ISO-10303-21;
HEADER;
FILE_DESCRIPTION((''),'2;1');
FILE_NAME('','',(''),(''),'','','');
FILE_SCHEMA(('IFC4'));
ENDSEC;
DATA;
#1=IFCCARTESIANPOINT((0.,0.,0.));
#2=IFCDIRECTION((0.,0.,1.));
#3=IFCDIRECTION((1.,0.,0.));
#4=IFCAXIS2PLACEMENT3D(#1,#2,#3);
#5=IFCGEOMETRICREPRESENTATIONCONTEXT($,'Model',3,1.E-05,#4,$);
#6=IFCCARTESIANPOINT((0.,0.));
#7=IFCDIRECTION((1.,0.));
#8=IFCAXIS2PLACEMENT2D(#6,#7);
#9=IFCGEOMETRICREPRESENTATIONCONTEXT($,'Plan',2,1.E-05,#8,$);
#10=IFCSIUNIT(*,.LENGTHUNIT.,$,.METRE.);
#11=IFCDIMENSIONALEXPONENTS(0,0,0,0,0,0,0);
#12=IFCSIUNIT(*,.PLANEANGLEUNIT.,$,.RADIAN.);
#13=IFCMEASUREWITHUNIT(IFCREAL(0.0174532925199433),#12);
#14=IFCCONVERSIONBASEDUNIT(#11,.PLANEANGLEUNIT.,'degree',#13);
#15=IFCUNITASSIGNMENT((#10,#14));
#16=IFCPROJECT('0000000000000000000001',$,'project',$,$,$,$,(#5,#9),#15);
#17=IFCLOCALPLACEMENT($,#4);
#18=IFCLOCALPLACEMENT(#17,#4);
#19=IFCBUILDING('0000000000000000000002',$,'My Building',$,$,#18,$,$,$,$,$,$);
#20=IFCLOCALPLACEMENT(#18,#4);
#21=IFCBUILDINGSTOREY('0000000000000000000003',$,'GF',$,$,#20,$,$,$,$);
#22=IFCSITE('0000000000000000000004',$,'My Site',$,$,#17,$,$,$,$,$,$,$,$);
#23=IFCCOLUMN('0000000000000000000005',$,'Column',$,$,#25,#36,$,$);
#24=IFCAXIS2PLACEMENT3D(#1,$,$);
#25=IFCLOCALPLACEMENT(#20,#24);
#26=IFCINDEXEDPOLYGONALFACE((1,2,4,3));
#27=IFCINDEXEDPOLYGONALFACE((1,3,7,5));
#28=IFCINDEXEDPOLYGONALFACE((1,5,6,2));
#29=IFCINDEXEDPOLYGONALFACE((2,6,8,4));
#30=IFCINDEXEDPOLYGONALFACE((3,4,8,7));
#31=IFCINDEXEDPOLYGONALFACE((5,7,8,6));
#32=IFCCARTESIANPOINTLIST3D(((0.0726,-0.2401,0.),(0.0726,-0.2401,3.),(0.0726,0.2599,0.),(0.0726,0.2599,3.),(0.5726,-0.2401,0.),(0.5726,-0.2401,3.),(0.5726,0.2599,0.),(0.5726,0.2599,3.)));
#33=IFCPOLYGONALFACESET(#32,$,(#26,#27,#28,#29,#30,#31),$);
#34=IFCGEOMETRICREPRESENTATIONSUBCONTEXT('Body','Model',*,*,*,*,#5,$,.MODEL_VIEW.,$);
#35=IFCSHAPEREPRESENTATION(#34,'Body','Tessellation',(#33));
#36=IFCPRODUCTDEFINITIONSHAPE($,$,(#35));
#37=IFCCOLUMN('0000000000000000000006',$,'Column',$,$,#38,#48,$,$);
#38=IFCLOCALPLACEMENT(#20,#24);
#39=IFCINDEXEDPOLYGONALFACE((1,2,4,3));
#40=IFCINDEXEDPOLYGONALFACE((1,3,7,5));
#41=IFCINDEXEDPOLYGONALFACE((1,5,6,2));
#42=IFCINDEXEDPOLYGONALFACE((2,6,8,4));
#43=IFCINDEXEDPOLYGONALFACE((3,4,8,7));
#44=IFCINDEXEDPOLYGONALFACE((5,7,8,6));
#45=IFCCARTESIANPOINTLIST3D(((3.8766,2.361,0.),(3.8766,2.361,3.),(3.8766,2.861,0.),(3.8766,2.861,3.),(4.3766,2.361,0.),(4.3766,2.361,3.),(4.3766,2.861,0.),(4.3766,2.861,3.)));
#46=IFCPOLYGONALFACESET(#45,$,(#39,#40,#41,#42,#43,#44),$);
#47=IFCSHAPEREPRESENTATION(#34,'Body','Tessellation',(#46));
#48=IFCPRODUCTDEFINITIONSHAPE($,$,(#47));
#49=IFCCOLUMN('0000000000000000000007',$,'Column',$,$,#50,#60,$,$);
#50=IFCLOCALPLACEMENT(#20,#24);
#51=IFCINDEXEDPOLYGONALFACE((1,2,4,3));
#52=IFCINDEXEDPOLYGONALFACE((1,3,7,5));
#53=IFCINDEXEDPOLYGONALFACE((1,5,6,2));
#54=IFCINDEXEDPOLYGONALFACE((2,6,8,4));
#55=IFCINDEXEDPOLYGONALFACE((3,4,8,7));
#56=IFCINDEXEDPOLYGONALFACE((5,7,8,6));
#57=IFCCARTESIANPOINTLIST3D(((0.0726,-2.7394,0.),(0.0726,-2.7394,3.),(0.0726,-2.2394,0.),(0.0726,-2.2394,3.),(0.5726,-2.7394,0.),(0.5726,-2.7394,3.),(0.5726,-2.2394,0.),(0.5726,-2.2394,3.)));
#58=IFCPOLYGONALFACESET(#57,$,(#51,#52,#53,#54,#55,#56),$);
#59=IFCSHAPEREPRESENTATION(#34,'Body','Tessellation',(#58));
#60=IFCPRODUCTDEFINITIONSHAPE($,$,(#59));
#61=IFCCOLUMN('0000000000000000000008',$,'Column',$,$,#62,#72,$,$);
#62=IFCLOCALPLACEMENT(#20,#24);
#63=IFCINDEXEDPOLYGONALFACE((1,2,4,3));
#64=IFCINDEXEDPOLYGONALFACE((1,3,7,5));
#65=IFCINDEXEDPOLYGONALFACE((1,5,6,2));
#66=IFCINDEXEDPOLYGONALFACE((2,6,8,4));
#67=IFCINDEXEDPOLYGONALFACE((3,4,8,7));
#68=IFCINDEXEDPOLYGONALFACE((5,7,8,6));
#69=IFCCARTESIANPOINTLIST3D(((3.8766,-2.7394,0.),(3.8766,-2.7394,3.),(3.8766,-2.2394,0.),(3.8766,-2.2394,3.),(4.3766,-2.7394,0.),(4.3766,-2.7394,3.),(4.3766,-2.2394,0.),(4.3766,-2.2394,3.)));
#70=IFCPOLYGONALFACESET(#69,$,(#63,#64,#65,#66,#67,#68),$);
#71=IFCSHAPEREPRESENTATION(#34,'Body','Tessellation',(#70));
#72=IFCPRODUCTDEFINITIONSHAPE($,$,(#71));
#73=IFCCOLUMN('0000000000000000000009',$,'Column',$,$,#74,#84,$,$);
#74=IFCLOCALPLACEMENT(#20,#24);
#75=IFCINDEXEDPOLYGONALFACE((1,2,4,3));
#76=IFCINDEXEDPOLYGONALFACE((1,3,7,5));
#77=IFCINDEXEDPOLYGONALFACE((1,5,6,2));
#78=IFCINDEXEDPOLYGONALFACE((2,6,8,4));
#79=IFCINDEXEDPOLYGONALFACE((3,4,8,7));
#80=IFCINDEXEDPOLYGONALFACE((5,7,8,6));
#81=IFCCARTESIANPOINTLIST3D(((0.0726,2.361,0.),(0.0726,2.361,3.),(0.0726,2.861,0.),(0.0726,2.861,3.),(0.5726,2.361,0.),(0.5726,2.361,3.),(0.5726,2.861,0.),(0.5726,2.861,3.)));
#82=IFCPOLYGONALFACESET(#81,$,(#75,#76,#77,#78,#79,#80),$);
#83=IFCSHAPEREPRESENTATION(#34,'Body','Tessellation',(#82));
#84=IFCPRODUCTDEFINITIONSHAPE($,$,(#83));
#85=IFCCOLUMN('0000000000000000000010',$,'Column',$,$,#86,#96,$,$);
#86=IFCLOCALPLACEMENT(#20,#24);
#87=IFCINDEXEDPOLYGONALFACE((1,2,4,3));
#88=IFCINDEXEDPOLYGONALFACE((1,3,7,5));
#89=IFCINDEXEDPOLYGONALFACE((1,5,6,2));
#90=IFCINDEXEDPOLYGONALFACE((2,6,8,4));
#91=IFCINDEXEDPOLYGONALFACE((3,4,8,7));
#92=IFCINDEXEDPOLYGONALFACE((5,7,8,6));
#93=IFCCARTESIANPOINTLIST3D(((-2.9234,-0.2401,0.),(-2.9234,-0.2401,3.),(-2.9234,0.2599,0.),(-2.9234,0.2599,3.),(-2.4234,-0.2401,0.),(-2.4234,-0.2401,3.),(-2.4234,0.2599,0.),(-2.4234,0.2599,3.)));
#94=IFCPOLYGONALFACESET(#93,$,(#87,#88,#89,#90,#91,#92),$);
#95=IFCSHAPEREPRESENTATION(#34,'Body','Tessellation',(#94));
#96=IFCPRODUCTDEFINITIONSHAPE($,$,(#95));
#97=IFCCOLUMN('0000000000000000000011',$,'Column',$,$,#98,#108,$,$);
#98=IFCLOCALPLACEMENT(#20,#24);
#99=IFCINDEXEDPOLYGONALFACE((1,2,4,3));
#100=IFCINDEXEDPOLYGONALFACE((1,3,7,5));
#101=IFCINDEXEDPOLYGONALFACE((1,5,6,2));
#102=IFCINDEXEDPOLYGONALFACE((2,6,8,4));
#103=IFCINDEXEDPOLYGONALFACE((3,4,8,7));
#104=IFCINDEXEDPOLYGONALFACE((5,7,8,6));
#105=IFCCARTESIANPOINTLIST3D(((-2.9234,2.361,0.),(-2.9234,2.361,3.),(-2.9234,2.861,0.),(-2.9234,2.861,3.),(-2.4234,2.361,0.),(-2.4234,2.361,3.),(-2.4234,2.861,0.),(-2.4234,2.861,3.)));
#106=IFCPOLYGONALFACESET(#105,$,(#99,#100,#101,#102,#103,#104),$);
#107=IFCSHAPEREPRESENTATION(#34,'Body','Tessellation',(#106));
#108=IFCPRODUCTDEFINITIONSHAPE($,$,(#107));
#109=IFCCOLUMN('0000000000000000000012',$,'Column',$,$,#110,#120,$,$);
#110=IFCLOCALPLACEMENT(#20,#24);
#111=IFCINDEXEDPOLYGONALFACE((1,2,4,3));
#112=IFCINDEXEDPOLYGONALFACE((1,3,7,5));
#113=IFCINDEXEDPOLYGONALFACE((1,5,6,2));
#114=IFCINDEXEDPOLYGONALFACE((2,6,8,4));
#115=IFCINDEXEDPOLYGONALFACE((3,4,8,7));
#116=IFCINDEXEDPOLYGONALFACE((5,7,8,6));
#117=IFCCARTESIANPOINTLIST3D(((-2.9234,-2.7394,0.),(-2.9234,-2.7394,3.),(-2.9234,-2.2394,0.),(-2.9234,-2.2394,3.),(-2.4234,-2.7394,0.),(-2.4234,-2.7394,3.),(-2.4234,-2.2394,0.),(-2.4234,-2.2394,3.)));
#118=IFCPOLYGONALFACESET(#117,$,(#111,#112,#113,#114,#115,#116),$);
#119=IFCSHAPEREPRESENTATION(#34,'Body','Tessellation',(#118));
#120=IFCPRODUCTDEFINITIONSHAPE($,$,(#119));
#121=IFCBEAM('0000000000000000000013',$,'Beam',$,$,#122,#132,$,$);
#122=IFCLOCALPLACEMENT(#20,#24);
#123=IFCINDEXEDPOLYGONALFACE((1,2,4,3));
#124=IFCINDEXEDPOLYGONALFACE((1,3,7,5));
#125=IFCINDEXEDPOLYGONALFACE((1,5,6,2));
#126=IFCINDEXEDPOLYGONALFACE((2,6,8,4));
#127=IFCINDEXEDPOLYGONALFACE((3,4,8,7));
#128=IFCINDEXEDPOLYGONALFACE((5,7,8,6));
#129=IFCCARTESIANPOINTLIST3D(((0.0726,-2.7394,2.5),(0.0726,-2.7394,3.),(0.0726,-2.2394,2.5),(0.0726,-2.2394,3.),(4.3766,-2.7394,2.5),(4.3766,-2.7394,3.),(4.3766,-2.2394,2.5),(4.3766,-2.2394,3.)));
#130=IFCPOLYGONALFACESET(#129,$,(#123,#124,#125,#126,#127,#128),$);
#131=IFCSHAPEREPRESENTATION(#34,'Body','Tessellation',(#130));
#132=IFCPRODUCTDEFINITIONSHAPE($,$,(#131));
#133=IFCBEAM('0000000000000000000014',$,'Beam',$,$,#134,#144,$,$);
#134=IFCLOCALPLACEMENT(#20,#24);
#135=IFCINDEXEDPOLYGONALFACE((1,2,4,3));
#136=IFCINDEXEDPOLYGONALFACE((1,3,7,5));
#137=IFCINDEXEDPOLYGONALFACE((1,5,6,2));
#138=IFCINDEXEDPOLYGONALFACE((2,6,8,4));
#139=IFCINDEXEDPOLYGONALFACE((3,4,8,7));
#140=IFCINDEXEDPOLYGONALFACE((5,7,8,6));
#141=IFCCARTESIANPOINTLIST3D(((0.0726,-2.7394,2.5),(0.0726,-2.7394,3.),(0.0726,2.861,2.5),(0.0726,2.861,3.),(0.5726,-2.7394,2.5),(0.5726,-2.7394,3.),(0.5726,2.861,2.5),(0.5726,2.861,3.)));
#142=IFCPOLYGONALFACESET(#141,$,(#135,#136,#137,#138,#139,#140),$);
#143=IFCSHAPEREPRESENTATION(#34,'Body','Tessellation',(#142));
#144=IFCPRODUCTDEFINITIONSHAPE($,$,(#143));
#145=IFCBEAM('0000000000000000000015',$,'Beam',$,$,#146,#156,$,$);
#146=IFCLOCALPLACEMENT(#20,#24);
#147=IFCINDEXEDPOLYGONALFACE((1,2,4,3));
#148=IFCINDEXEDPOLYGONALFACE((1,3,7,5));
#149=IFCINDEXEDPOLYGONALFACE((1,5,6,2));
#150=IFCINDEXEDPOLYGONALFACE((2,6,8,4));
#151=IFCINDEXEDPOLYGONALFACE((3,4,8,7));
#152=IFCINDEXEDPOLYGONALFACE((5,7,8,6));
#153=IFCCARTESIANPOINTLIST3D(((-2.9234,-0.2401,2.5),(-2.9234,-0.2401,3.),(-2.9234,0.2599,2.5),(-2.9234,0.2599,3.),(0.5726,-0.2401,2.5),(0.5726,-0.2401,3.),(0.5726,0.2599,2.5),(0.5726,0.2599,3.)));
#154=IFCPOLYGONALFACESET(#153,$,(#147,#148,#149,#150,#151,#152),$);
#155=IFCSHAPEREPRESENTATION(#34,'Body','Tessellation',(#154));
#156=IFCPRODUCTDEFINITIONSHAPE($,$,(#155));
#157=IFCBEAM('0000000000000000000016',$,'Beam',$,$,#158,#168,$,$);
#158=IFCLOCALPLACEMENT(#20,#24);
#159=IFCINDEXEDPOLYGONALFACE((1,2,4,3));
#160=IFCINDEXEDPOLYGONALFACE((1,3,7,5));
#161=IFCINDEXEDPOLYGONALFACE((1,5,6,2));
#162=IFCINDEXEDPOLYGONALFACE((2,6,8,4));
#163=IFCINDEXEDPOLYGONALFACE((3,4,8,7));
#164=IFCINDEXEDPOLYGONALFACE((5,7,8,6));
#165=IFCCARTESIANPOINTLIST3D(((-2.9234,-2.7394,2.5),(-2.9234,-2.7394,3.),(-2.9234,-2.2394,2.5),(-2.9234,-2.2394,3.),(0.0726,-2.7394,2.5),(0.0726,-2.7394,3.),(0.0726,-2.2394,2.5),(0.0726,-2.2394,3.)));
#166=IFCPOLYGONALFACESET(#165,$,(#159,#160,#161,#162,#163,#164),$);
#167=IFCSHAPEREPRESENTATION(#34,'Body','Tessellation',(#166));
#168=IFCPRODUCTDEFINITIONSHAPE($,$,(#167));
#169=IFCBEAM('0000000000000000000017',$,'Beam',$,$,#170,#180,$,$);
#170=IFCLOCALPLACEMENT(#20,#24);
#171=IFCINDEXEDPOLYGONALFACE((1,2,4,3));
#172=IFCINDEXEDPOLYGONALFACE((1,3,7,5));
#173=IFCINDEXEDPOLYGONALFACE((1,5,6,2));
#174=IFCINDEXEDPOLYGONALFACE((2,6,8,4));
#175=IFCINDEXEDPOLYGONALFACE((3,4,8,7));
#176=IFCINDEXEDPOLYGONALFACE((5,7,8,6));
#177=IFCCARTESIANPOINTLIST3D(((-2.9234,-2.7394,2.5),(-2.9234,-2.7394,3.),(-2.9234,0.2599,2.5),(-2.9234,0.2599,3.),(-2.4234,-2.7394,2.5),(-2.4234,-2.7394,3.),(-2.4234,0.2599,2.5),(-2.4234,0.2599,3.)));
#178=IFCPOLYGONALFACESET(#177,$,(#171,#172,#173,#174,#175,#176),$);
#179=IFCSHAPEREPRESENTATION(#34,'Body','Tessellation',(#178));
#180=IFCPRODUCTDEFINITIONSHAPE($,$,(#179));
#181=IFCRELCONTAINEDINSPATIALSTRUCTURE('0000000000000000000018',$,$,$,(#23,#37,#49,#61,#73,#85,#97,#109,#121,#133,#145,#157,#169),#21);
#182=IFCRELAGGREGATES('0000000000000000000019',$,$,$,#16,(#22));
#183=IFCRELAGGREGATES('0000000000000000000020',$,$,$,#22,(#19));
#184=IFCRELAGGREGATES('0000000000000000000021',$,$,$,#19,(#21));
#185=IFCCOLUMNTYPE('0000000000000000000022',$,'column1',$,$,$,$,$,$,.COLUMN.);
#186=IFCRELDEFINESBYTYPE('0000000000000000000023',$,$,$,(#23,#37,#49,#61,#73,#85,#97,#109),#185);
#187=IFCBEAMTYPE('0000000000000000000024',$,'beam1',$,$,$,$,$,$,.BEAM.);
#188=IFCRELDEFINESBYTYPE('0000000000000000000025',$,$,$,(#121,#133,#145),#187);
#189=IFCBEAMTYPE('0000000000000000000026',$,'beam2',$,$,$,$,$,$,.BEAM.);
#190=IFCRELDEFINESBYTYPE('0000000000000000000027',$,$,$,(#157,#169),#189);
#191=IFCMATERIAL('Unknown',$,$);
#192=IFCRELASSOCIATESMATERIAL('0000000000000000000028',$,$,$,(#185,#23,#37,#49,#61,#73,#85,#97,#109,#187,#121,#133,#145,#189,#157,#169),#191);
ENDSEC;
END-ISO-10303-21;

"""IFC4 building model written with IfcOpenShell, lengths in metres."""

from ifc_helpers import new_model, entity, si_unit, converted_unit, frame, origin_with_axes, origin_2d_with_axis, place, context, subcontext, project, spatial, rectangle, extrude, material, material_profile, profile_set, profile_usage, type_object, element, save


model = new_model("IFC4")

# Units and contexts
model_context = context("Model", 3, precision=1e-05, world=origin_with_axes())
plan_context = context("Plan", 2, precision=1e-05, world=origin_2d_with_axis())
body_context_1 = subcontext(model_context, "Body", "Model", "MODEL_VIEW")
ifc_project = project(units=[si_unit("LENGTHUNIT", "METRE"), converted_unit("PLANEANGLEUNIT", "degree", entity("IfcReal", 0.0174532925199433), si_unit("PLANEANGLEUNIT", "RADIAN"), dimensions=[0, 0, 0, 0, 0, 0, 0])], contexts=[model_context, plan_context])

# Site, building, storey
site_placement = place(None, origin_with_axes())
site = spatial("IfcSite", under=ifc_project, at=site_placement, Name="My Site")
building_placement = place(site_placement, origin_with_axes())
building = spatial("IfcBuilding", under=site, at=building_placement, Name="My Building")
storey_placement = place(building_placement, origin_with_axes())
storey = spatial("IfcBuildingStorey", under=building, at=storey_placement, Name="GF")

# Columns
ifc_material = material(Name="Unknown")
ifc_material_profile_1 = material_profile(ifc_material, rectangle(XDim=0.5, YDim=0.5))
ifc_profile_set_1 = profile_set([ifc_material_profile_1])
ifc_profile_usage_1 = profile_usage(ifc_profile_set_1, cardinal=5)
column_type = type_object("IfcColumnType", Name="column1", PredefinedType="COLUMN", material=ifc_profile_set_1)
column_1_placement = place(storey_placement, frame((0.3226, 0.0099, 0.0), z_axis=(0.0, 0.0, 1.0), x_axis=(1.0, 0.0, 0.0)))
element("IfcColumn", 1, at=column_1_placement, inside=storey, type_object=column_type, material=ifc_profile_usage_1, Name="Column", context=body_context_1, shape_type="SweptSolid", body=[
    extrude(rectangle(XDim=0.5, YDim=0.5), origin_with_axes(), (0.0, 0.0, 1.0), 3.0),
])
ifc_profile_usage_2 = profile_usage(ifc_profile_set_1, cardinal=5)
column_2_placement = place(storey_placement, frame((4.1266, 2.611, 0.0), z_axis=(0.0, 0.0, 1.0), x_axis=(1.0, 0.0, 0.0)))
element("IfcColumn", 2, at=column_2_placement, inside=storey, type_object=column_type, material=ifc_profile_usage_2, Name="Column", context=body_context_1, shape_type="SweptSolid", body=[
    extrude(rectangle(XDim=0.5, YDim=0.5), origin_with_axes(), (0.0, 0.0, 1.0), 3.0),
])
ifc_profile_usage_3 = profile_usage(ifc_profile_set_1, cardinal=5)
column_3_placement = place(storey_placement, frame((0.3226, -2.4894, 0.0), z_axis=(0.0, 0.0, 1.0), x_axis=(1.0, 0.0, 0.0)))
element("IfcColumn", 3, at=column_3_placement, inside=storey, type_object=column_type, material=ifc_profile_usage_3, Name="Column", context=body_context_1, shape_type="SweptSolid", body=[
    extrude(rectangle(XDim=0.5, YDim=0.5), origin_with_axes(), (0.0, 0.0, 1.0), 3.0),
])
ifc_profile_usage_4 = profile_usage(ifc_profile_set_1, cardinal=5)
column_4_placement = place(storey_placement, frame((4.1266, -2.4894, 0.0), z_axis=(0.0, 0.0, 1.0), x_axis=(1.0, 0.0, 0.0)))
element("IfcColumn", 4, at=column_4_placement, inside=storey, type_object=column_type, material=ifc_profile_usage_4, Name="Column", context=body_context_1, shape_type="SweptSolid", body=[
    extrude(rectangle(XDim=0.5, YDim=0.5), origin_with_axes(), (0.0, 0.0, 1.0), 3.0),
])
ifc_profile_usage_5 = profile_usage(ifc_profile_set_1, cardinal=5)
column_5_placement = place(storey_placement, frame((0.3226, 2.611, 0.0), z_axis=(0.0, 0.0, 1.0), x_axis=(1.0, 0.0, 0.0)))
element("IfcColumn", 5, at=column_5_placement, inside=storey, type_object=column_type, material=ifc_profile_usage_5, Name="Column", context=body_context_1, shape_type="SweptSolid", body=[
    extrude(rectangle(XDim=0.5, YDim=0.5), origin_with_axes(), (0.0, 0.0, 1.0), 3.0),
])
ifc_profile_usage_6 = profile_usage(ifc_profile_set_1, cardinal=5)
column_6_placement = place(storey_placement, frame((-2.6734, 0.0099, 0.0), z_axis=(0.0, 0.0, 1.0), x_axis=(1.0, 0.0, 0.0)))
element("IfcColumn", 6, at=column_6_placement, inside=storey, type_object=column_type, material=ifc_profile_usage_6, Name="Column", context=body_context_1, shape_type="SweptSolid", body=[
    extrude(rectangle(XDim=0.5, YDim=0.5), origin_with_axes(), (0.0, 0.0, 1.0), 3.0),
])
ifc_profile_usage_7 = profile_usage(ifc_profile_set_1, cardinal=5)
column_7_placement = place(storey_placement, frame((-2.6734, 2.611, 0.0), z_axis=(0.0, 0.0, 1.0), x_axis=(1.0, 0.0, 0.0)))
element("IfcColumn", 7, at=column_7_placement, inside=storey, type_object=column_type, material=ifc_profile_usage_7, Name="Column", context=body_context_1, shape_type="SweptSolid", body=[
    extrude(rectangle(XDim=0.5, YDim=0.5), origin_with_axes(), (0.0, 0.0, 1.0), 3.0),
])
ifc_profile_usage_8 = profile_usage(ifc_profile_set_1, cardinal=5)
column_8_placement = place(storey_placement, frame((-2.6734, -2.4894, 0.0), z_axis=(0.0, 0.0, 1.0), x_axis=(1.0, 0.0, 0.0)))
element("IfcColumn", 8, at=column_8_placement, inside=storey, type_object=column_type, material=ifc_profile_usage_8, Name="Column", context=body_context_1, shape_type="SweptSolid", body=[
    extrude(rectangle(XDim=0.5, YDim=0.5), origin_with_axes(), (0.0, 0.0, 1.0), 3.0),
])

# Beams
ifc_material_profile_2 = material_profile(ifc_material, rectangle(XDim=0.5, YDim=0.5))
ifc_profile_set_2 = profile_set([ifc_material_profile_2])
ifc_profile_usage_9 = profile_usage(ifc_profile_set_2, cardinal=7)
beam_type_1 = type_object("IfcBeamType", Name="beam1", PredefinedType="BEAM", material=ifc_profile_set_2)
beam_1_placement = place(storey_placement, frame((4.3766, -2.7394, 3.0), z_axis=(-1.0, 0.0, 0.0), x_axis=(0.0, -1.0, 0.0)))
element("IfcBeam", 9, at=beam_1_placement, inside=storey, type_object=beam_type_1, material=ifc_profile_usage_9, Name="Beam", context=body_context_1, shape_type="SweptSolid", body=[
    extrude(rectangle(XDim=0.5, YDim=0.5), frame((-0.25, -0.25, 0.0), z_axis=(0.0, 0.0, 1.0), x_axis=(1.0, 0.0, 0.0)), (0.0, 0.0, 1.0), 4.304),
])
ifc_profile_usage_10 = profile_usage(ifc_profile_set_2, cardinal=7)
beam_2_placement = place(storey_placement, frame((0.0726, -2.7394, 3.0), z_axis=(0.0, 1.0, 0.0), x_axis=(-1.0, 0.0, 0.0)))
element("IfcBeam", 10, at=beam_2_placement, inside=storey, type_object=beam_type_1, material=ifc_profile_usage_10, Name="Beam", context=body_context_1, shape_type="SweptSolid", body=[
    extrude(rectangle(XDim=0.5, YDim=0.5), frame((-0.25, -0.25, 0.0), z_axis=(0.0, 0.0, 1.0), x_axis=(1.0, 0.0, 0.0)), (0.0, 0.0, 1.0), 5.6004),
])
ifc_profile_usage_11 = profile_usage(ifc_profile_set_2, cardinal=7)
beam_3_placement = place(storey_placement, frame((0.5726, -0.2401, 3.0), z_axis=(-1.0, 0.0, 0.0), x_axis=(0.0, -1.0, 0.0)))
element("IfcBeam", 11, at=beam_3_placement, inside=storey, type_object=beam_type_1, material=ifc_profile_usage_11, Name="Beam", context=body_context_1, shape_type="SweptSolid", body=[
    extrude(rectangle(XDim=0.5, YDim=0.5), frame((-0.25, -0.25, 0.0), z_axis=(0.0, 0.0, 1.0), x_axis=(1.0, 0.0, 0.0)), (0.0, 0.0, 1.0), 3.496),
])
ifc_material_profile_3 = material_profile(ifc_material, rectangle(XDim=0.5, YDim=0.5))
ifc_profile_set_3 = profile_set([ifc_material_profile_3])
ifc_profile_usage_12 = profile_usage(ifc_profile_set_3, cardinal=7)
beam_type_2 = type_object("IfcBeamType", Name="beam2", PredefinedType="BEAM", material=ifc_profile_set_3)
beam_4_placement = place(storey_placement, frame((0.0726, -2.7394, 3.0), z_axis=(-1.0, 0.0, 0.0), x_axis=(0.0, -1.0, 0.0)))
element("IfcBeam", 12, at=beam_4_placement, inside=storey, type_object=beam_type_2, material=ifc_profile_usage_12, Name="Beam", context=body_context_1, shape_type="SweptSolid", body=[
    extrude(rectangle(XDim=0.5, YDim=0.5), frame((-0.25, -0.25, 0.0), z_axis=(0.0, 0.0, 1.0), x_axis=(1.0, 0.0, 0.0)), (0.0, 0.0, 1.0), 2.996),
])
ifc_profile_usage_13 = profile_usage(ifc_profile_set_3, cardinal=7)
beam_5_placement = place(storey_placement, frame((-2.4234, 0.2599, 3.0), z_axis=(-0.000002, -1.0, 0.0), x_axis=(1.0, -0.000002, 0.0)))
element("IfcBeam", 13, at=beam_5_placement, inside=storey, type_object=beam_type_2, material=ifc_profile_usage_13, Name="Beam", context=body_context_1, shape_type="SweptSolid", body=[
    extrude(rectangle(XDim=0.5, YDim=0.5), frame((-0.25, -0.25, 0.0), z_axis=(0.0, 0.0, 1.0), x_axis=(1.0, 0.0, 0.0)), (0.0, 0.0, 1.0), 2.9993),
])

save(model, "model.ifc")
